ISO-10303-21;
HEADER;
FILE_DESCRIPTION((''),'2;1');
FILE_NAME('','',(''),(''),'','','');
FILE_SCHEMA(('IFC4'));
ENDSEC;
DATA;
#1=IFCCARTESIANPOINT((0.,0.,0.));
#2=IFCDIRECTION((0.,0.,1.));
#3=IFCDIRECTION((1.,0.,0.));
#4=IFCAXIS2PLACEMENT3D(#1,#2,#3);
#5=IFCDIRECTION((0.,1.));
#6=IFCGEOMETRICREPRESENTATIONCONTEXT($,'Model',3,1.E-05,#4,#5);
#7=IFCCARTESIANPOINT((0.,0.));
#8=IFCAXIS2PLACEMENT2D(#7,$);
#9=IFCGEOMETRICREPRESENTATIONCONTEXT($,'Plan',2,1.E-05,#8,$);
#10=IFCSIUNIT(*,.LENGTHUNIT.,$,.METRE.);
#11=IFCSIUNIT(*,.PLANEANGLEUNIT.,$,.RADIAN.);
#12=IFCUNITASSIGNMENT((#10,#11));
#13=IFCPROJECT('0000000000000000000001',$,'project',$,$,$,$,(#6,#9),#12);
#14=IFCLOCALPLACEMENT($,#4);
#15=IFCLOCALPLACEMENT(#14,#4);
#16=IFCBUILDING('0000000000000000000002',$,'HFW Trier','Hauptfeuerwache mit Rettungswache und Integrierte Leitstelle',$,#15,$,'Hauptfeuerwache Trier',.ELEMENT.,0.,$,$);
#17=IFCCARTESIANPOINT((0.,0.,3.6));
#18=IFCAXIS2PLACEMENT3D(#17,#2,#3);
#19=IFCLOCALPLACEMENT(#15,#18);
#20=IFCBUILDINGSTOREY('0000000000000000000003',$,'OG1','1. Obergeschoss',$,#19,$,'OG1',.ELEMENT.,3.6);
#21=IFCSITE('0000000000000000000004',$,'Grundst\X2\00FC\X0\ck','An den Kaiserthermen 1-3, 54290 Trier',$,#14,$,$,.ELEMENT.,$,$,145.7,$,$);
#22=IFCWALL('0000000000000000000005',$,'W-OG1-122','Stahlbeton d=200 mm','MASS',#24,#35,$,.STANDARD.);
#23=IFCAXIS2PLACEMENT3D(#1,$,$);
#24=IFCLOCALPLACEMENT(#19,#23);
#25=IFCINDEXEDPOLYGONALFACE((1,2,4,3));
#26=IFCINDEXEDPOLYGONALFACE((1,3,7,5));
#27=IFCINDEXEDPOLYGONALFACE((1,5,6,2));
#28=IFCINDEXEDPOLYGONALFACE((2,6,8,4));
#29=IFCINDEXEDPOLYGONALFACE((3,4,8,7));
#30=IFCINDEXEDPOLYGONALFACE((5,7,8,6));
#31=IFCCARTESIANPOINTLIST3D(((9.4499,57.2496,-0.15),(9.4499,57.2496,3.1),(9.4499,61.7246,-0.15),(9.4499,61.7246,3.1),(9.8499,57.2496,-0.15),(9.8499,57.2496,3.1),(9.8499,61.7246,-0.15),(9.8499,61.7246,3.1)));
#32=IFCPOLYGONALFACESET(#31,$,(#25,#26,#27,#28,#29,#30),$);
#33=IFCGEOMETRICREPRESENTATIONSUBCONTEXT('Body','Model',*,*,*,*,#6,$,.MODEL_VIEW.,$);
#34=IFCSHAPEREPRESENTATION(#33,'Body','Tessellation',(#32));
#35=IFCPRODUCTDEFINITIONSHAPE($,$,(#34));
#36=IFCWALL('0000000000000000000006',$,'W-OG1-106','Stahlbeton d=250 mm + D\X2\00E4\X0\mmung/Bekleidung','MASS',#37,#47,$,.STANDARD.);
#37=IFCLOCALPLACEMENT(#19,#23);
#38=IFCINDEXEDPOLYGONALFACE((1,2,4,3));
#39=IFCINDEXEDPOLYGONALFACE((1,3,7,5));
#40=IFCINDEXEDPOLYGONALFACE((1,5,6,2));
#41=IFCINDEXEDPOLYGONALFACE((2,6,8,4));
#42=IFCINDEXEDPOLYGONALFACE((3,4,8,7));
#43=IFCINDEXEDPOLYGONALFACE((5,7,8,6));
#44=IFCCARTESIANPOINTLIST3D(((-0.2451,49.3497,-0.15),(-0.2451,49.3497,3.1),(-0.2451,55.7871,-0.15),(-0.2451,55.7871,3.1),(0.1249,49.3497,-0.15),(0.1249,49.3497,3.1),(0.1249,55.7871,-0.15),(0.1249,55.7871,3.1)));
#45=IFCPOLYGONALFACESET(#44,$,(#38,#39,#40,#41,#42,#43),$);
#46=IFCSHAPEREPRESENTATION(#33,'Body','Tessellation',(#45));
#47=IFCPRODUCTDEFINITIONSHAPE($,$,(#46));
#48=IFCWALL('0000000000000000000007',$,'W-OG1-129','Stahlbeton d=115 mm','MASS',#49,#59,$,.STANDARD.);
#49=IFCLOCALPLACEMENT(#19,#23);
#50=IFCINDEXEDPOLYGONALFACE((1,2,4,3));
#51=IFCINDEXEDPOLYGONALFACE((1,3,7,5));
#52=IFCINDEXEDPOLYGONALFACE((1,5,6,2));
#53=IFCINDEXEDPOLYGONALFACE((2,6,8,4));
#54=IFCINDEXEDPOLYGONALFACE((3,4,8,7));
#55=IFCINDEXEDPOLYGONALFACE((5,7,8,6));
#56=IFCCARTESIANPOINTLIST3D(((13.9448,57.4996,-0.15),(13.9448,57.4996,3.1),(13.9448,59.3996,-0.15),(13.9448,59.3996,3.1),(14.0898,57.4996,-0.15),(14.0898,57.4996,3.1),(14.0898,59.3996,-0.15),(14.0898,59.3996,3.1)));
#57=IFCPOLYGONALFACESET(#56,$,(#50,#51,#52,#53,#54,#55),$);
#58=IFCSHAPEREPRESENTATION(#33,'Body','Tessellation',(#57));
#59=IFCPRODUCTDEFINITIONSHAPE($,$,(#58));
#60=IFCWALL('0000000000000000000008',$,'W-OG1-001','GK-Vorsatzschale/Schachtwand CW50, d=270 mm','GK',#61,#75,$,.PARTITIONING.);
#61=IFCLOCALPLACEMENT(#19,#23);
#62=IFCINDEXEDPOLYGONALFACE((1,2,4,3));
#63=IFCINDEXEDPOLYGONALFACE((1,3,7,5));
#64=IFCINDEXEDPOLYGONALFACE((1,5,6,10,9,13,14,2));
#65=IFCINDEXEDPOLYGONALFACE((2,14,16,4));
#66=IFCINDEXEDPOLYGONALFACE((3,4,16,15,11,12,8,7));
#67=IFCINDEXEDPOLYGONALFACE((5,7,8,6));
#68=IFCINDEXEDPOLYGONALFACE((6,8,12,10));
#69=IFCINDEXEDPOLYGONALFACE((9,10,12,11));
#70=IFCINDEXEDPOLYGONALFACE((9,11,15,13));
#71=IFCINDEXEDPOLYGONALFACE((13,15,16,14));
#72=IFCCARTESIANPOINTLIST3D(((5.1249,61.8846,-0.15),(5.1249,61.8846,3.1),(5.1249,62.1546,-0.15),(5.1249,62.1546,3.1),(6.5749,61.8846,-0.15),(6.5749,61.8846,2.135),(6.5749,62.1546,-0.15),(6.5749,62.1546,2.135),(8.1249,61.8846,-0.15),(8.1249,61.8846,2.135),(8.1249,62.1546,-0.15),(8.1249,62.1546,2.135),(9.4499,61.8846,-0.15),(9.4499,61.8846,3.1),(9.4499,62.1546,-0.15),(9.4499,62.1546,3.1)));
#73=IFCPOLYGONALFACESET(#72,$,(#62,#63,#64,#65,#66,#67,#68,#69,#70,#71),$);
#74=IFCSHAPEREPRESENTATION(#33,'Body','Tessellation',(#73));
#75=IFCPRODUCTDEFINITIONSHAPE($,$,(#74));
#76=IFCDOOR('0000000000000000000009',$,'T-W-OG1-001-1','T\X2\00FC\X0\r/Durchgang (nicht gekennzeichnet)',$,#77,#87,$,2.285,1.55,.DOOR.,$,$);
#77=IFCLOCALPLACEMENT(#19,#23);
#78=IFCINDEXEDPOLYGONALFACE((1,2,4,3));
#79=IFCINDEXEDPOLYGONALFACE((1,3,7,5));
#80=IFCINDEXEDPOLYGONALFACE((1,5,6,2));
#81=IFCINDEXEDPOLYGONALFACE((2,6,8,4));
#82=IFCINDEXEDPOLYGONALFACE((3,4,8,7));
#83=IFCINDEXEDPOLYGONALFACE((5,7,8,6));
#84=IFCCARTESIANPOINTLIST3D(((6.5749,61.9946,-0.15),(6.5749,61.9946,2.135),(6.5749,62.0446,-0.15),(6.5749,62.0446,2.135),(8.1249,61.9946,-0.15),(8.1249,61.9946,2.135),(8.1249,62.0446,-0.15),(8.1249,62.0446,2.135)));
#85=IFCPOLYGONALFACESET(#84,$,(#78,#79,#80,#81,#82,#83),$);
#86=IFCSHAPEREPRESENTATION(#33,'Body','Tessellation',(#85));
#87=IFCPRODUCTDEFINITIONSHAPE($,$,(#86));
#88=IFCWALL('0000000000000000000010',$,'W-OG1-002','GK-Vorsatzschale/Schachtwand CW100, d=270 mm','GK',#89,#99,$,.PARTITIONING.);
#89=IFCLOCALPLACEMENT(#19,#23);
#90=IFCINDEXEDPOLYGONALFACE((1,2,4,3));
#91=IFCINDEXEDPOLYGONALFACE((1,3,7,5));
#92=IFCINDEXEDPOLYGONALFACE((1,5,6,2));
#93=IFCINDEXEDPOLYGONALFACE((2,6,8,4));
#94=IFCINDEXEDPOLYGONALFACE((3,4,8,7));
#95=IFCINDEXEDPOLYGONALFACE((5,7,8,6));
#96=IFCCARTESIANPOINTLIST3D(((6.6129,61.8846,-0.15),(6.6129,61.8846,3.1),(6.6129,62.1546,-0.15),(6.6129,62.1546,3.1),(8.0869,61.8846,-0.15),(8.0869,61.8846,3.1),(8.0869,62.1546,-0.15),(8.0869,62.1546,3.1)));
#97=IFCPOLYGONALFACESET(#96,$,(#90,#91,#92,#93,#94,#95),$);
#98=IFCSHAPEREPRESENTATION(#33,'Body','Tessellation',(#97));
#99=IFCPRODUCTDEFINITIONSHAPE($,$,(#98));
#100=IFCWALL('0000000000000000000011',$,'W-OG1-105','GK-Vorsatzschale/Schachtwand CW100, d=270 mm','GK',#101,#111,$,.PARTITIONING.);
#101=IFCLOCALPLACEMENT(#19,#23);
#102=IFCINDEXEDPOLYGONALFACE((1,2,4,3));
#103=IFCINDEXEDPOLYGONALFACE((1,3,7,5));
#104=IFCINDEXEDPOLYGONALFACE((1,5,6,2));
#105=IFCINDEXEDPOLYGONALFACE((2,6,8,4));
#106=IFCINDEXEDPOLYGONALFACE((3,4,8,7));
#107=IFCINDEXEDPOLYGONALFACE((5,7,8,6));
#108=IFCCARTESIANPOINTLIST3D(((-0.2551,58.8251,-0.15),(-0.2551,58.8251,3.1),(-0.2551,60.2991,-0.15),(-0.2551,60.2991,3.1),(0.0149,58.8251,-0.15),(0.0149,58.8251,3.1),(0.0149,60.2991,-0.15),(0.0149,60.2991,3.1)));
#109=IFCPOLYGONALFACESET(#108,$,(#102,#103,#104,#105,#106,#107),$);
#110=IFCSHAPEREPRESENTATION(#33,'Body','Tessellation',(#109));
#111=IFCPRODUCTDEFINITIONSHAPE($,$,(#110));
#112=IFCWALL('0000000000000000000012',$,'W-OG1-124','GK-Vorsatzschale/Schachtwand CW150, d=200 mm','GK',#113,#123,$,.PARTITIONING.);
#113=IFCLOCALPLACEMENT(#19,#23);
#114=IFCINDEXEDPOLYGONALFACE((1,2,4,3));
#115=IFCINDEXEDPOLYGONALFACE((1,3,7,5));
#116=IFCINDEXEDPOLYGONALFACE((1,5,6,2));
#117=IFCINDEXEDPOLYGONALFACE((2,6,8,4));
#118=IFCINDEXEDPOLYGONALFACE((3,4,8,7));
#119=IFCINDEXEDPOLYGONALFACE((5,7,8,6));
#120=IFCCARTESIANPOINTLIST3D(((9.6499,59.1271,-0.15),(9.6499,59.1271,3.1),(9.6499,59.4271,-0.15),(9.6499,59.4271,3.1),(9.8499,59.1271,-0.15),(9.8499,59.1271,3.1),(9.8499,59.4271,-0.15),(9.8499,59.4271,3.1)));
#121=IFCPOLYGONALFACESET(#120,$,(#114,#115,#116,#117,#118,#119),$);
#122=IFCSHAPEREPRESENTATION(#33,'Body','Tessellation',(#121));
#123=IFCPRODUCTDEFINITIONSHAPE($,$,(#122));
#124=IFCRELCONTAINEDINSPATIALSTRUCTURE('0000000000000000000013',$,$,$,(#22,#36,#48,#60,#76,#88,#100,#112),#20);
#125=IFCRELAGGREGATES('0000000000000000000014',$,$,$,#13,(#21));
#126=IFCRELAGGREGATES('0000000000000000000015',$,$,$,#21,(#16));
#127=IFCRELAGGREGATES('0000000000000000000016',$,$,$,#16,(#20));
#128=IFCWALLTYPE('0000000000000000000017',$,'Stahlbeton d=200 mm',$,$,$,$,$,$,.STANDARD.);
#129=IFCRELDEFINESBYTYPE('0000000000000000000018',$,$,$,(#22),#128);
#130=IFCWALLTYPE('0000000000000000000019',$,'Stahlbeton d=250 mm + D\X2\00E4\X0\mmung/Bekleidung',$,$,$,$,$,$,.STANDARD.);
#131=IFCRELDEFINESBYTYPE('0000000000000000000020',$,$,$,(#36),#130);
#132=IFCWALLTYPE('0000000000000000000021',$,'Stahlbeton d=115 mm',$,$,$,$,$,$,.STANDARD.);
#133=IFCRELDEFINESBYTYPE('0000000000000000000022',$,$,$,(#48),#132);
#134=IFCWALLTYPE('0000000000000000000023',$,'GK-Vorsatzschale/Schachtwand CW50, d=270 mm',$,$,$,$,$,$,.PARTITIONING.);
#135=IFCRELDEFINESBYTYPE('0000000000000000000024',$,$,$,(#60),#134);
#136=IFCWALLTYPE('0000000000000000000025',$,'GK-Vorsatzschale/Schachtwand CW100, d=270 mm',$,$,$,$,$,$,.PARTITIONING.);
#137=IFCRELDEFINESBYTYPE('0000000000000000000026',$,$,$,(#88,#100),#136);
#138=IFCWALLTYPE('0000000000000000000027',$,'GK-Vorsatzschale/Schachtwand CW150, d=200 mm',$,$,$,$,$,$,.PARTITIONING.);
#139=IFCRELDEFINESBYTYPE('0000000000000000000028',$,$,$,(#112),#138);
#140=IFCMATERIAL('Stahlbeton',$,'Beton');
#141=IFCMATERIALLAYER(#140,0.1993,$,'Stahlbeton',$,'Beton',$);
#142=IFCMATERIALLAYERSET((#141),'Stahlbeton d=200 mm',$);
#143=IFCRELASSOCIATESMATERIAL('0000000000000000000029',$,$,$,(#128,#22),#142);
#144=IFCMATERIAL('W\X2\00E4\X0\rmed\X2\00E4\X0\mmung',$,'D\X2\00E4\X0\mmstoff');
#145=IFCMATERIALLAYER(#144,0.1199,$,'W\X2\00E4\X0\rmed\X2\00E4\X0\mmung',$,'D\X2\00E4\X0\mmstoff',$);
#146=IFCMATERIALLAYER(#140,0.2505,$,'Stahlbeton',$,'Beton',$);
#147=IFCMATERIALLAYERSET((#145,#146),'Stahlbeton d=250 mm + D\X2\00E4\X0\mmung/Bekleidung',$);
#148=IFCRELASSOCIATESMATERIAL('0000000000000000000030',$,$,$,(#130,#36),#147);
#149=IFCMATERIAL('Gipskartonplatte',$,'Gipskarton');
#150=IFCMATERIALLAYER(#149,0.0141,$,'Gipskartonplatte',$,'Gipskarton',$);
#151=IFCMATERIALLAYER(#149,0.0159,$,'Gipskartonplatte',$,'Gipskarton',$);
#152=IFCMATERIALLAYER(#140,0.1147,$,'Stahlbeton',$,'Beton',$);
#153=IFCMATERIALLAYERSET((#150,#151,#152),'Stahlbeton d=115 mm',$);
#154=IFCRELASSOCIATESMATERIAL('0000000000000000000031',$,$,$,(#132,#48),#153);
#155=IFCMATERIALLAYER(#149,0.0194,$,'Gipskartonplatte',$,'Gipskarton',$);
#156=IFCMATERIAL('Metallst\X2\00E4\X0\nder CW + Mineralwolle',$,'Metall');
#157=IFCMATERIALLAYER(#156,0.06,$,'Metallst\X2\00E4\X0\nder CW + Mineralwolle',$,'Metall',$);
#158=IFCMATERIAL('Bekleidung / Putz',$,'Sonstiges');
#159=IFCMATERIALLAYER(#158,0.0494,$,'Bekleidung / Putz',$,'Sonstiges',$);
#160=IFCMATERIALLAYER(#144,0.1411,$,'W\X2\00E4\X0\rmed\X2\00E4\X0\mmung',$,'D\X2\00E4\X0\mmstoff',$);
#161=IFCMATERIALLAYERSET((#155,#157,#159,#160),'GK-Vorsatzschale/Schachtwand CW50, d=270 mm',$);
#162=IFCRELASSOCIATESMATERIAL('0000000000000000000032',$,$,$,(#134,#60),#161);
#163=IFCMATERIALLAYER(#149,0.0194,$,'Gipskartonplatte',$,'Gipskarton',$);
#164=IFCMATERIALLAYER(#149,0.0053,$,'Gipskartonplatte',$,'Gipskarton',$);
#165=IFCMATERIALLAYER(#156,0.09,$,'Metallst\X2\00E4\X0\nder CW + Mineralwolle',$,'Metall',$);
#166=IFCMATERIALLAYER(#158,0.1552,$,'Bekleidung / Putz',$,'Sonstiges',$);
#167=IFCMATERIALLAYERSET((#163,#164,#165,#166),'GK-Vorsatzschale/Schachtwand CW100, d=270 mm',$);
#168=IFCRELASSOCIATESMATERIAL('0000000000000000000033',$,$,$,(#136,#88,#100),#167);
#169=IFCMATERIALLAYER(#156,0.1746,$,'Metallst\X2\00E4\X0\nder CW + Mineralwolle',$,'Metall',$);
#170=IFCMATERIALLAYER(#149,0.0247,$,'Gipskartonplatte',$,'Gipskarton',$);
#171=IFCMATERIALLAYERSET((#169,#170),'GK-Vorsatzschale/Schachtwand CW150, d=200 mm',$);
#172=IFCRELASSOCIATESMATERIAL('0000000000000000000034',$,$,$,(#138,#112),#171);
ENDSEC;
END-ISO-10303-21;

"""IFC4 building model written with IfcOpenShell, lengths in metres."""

from ifc_helpers import new_model, si_unit, direction, frame, frame_2d, origin_with_axes, origin_2d, place, context, subcontext, project, spatial, rectangle, extrude, material, layer, layer_set, layer_usage, type_object, element, fill, save


model = new_model("IFC4")

# Units and contexts
model_context = context("Model", 3, precision=1e-05, world=origin_with_axes(), true_north=direction((0.0, 1.0)))
plan_context = context("Plan", 2, precision=1e-05, world=origin_2d())
body_context = subcontext(model_context, "Body", "Model", "MODEL_VIEW")
ifc_project = project(units=[si_unit("LENGTHUNIT", "METRE"), si_unit("PLANEANGLEUNIT", "RADIAN")], contexts=[model_context, plan_context])

# Site, building, storey
site_placement = place(None, origin_with_axes())
site = spatial("IfcSite", under=ifc_project, at=site_placement, Name="Grundstück", Description="An den Kaiserthermen 1-3, 54290 Trier", CompositionType="ELEMENT", RefElevation=145.7)
building_placement = place(site_placement, origin_with_axes())
building = spatial("IfcBuilding", under=site, at=building_placement, Name="HFW Trier", Description="Hauptfeuerwache mit Rettungswache und Integrierte Leitstelle", LongName="Hauptfeuerwache Trier", CompositionType="ELEMENT", ElevationOfRefHeight=0.0)
storey_placement = place(building_placement, frame((0.0, 0.0, 3.6), z_axis=(0.0, 0.0, 1.0), x_axis=(1.0, 0.0, 0.0)))
storey = spatial("IfcBuildingStorey", under=building, at=storey_placement, Name="OG1", Description="1. Obergeschoss", LongName="OG1", CompositionType="ELEMENT", Elevation=3.6)

# Shared definitions
ifc_material_1 = material(Name="Stahlbeton", Category="Beton")

# Shared definitions
ifc_material_2 = material(Name="Gipskartonplatte", Category="Gipskarton")
ifc_material_3 = material(Name="Metallständer CW + Mineralwolle", Category="Metall")

# Walls
ifc_layer_1 = layer(ifc_material_1, 0.1993, Name="Stahlbeton", Category="Beton")
ifc_layer_set_1 = layer_set([ifc_layer_1], Name="Stahlbeton d=200 mm")
wall_type_1 = type_object("IfcWallType", Name="Stahlbeton d=200 mm", PredefinedType="STANDARD", material=ifc_layer_set_1)
ifc_layer_usage_1 = layer_usage(ifc_layer_set_1, "AXIS2", "POSITIVE", -0.2)
wall_1_placement = place(storey_placement, frame((9.6499, 61.7246, -0.15), z_axis=(0.0, 0.0, 1.0), x_axis=(0.0, -1.0, 0.0)))
element("IfcWall", 1, at=wall_1_placement, inside=storey, type_object=wall_type_1, material=ifc_layer_usage_1, Name="W-OG1-122", Description="Stahlbeton d=200 mm", ObjectType="MASS", PredefinedType="STANDARD", context=body_context, shape_type="SweptSolid", body=[
    extrude(rectangle(XDim=4.475, YDim=0.4, at=frame_2d((2.2375, 0.0))), origin_with_axes(), (0.0, 0.0, 1.0), 3.25),
])
ifc_material_4 = material(Name="Wärmedämmung", Category="Dämmstoff")
ifc_layer_2 = layer(ifc_material_4, 0.1199, Name="Wärmedämmung", Category="Dämmstoff")
ifc_layer_3 = layer(ifc_material_1, 0.2505, Name="Stahlbeton", Category="Beton")
ifc_layer_set_2 = layer_set([ifc_layer_2, ifc_layer_3], Name="Stahlbeton d=250 mm + Dämmung/Bekleidung")
ifc_layer_usage_2 = layer_usage(ifc_layer_set_2, "AXIS2", "POSITIVE", -0.185)
wall_type_2 = type_object("IfcWallType", Name="Stahlbeton d=250 mm + Dämmung/Bekleidung", PredefinedType="STANDARD", material=ifc_layer_set_2)
wall_2_placement = place(storey_placement, frame((-0.0601, 55.7871, -0.15), z_axis=(0.0, 0.0, 1.0), x_axis=(0.0, -1.0, 0.0)))
element("IfcWall", 2, at=wall_2_placement, inside=storey, type_object=wall_type_2, material=ifc_layer_usage_2, Name="W-OG1-106", Description="Stahlbeton d=250 mm + Dämmung/Bekleidung", ObjectType="MASS", PredefinedType="STANDARD", context=body_context, shape_type="SweptSolid", body=[
    extrude(rectangle(XDim=6.4374, YDim=0.37, at=frame_2d((3.2187, 0.0))), origin_with_axes(), (0.0, 0.0, 1.0), 3.25),
])
ifc_layer_4 = layer(ifc_material_2, 0.0141, Name="Gipskartonplatte", Category="Gipskarton")
ifc_layer_5 = layer(ifc_material_2, 0.0159, Name="Gipskartonplatte", Category="Gipskarton")
ifc_layer_6 = layer(ifc_material_1, 0.1147, Name="Stahlbeton", Category="Beton")
ifc_layer_set_3 = layer_set([ifc_layer_4, ifc_layer_5, ifc_layer_6], Name="Stahlbeton d=115 mm")
ifc_layer_usage_3 = layer_usage(ifc_layer_set_3, "AXIS2", "POSITIVE", -0.0725)
wall_type_3 = type_object("IfcWallType", Name="Stahlbeton d=115 mm", PredefinedType="STANDARD", material=ifc_layer_set_3)
wall_3_placement = place(storey_placement, frame((14.0173, 59.3996, -0.15), z_axis=(0.0, 0.0, 1.0), x_axis=(0.0, -1.0, 0.0)))
element("IfcWall", 3, at=wall_3_placement, inside=storey, type_object=wall_type_3, material=ifc_layer_usage_3, Name="W-OG1-129", Description="Stahlbeton d=115 mm", ObjectType="MASS", PredefinedType="STANDARD", context=body_context, shape_type="SweptSolid", body=[
    extrude(rectangle(XDim=1.9, YDim=0.145, at=frame_2d((0.95, 0.0))), origin_with_axes(), (0.0, 0.0, 1.0), 3.25),
])

# Wall, opening, door
ifc_layer_7 = layer(ifc_material_2, 0.0194, Name="Gipskartonplatte", Category="Gipskarton")
ifc_layer_8 = layer(ifc_material_3, 0.06, Name="Metallständer CW + Mineralwolle", Category="Metall")
ifc_material_5 = material(Name="Bekleidung / Putz", Category="Sonstiges")
ifc_layer_9 = layer(ifc_material_5, 0.0494, Name="Bekleidung / Putz", Category="Sonstiges")
ifc_layer_10 = layer(ifc_material_4, 0.1411, Name="Wärmedämmung", Category="Dämmstoff")
ifc_layer_set_4 = layer_set([ifc_layer_7, ifc_layer_8, ifc_layer_9, ifc_layer_10], Name="GK-Vorsatzschale/Schachtwand CW50, d=270 mm")
ifc_layer_usage_4 = layer_usage(ifc_layer_set_4, "AXIS2", "POSITIVE", -0.135)
wall_type_4 = type_object("IfcWallType", Name="GK-Vorsatzschale/Schachtwand CW50, d=270 mm", PredefinedType="PARTITIONING", material=ifc_layer_set_4)
wall_4_placement = place(storey_placement, frame((5.1249, 62.0196, -0.15), z_axis=(0.0, 0.0, 1.0), x_axis=(1.0, 0.0, 0.0)))
wall_4 = element("IfcWall", 4, at=wall_4_placement, inside=storey, type_object=wall_type_4, material=ifc_layer_usage_4, Name="W-OG1-001", Description="GK-Vorsatzschale/Schachtwand CW50, d=270 mm", ObjectType="GK", PredefinedType="PARTITIONING", context=body_context, shape_type="SweptSolid", body=[
    extrude(rectangle(XDim=4.325, YDim=0.27, at=frame_2d((2.1625, 0.0))), origin_with_axes(), (0.0, 0.0, 1.0), 3.25),
])
opening_1_placement = place(wall_4_placement, frame((1.45, 0.0, 0.0), z_axis=(0.0, 0.0, 1.0), x_axis=(1.0, 0.0, 0.0)))
opening_1 = element("IfcOpeningElement", 5, at=opening_1_placement, cuts=wall_4, PredefinedType="OPENING", context=body_context, shape_type="SweptSolid", body=[
    extrude(rectangle(XDim=1.55, YDim=0.37, at=frame_2d((0.775, 0.0))), origin_with_axes(), (0.0, 0.0, 1.0), 2.285),
])
door_1_placement = place(wall_4_placement, frame((1.45, 0.0, 0.0), z_axis=(0.0, 0.0, 1.0), x_axis=(1.0, 0.0, 0.0)))
door_1 = element("IfcDoor", 6, at=door_1_placement, inside=storey, Name="T-W-OG1-001-1", Description="Tür/Durchgang (nicht gekennzeichnet)", OverallHeight=2.285, OverallWidth=1.55, PredefinedType="DOOR", context=body_context, shape_type="SweptSolid", body=[
    extrude(rectangle(XDim=1.55, YDim=0.05, at=frame_2d((0.775, 0.0))), origin_with_axes(), (0.0, 0.0, 1.0), 2.285),
])
fill(opening_1, door_1)

# Walls
ifc_layer_11 = layer(ifc_material_2, 0.0194, Name="Gipskartonplatte", Category="Gipskarton")
ifc_layer_12 = layer(ifc_material_2, 0.0053, Name="Gipskartonplatte", Category="Gipskarton")
ifc_layer_13 = layer(ifc_material_3, 0.09, Name="Metallständer CW + Mineralwolle", Category="Metall")
ifc_layer_14 = layer(ifc_material_5, 0.1552, Name="Bekleidung / Putz", Category="Sonstiges")
ifc_layer_set_5 = layer_set([ifc_layer_11, ifc_layer_12, ifc_layer_13, ifc_layer_14], Name="GK-Vorsatzschale/Schachtwand CW100, d=270 mm")
ifc_layer_usage_5 = layer_usage(ifc_layer_set_5, "AXIS2", "POSITIVE", -0.135)
wall_type_5 = type_object("IfcWallType", Name="GK-Vorsatzschale/Schachtwand CW100, d=270 mm", PredefinedType="PARTITIONING", material=ifc_layer_set_5)
wall_5_placement = place(storey_placement, frame((6.6129, 62.0196, -0.15), z_axis=(0.0, 0.0, 1.0), x_axis=(1.0, 0.0, 0.0)))
element("IfcWall", 7, at=wall_5_placement, inside=storey, type_object=wall_type_5, material=ifc_layer_usage_5, Name="W-OG1-002", Description="GK-Vorsatzschale/Schachtwand CW100, d=270 mm", ObjectType="GK", PredefinedType="PARTITIONING", context=body_context, shape_type="SweptSolid", body=[
    extrude(rectangle(XDim=1.474, YDim=0.27, at=frame_2d((0.737, 0.0))), origin_with_axes(), (0.0, 0.0, 1.0), 3.25),
])
ifc_layer_usage_6 = layer_usage(ifc_layer_set_5, "AXIS2", "POSITIVE", -0.135)
wall_6_placement = place(storey_placement, frame((-0.1201, 60.2991, -0.15), z_axis=(0.0, 0.0, 1.0), x_axis=(0.0, -1.0, 0.0)))
element("IfcWall", 8, at=wall_6_placement, inside=storey, type_object=wall_type_5, material=ifc_layer_usage_6, Name="W-OG1-105", Description="GK-Vorsatzschale/Schachtwand CW100, d=270 mm", ObjectType="GK", PredefinedType="PARTITIONING", context=body_context, shape_type="SweptSolid", body=[
    extrude(rectangle(XDim=1.474, YDim=0.27, at=frame_2d((0.737, 0.0))), origin_with_axes(), (0.0, 0.0, 1.0), 3.25),
])
ifc_layer_15 = layer(ifc_material_3, 0.1746, Name="Metallständer CW + Mineralwolle", Category="Metall")
ifc_layer_16 = layer(ifc_material_2, 0.0247, Name="Gipskartonplatte", Category="Gipskarton")
ifc_layer_set_6 = layer_set([ifc_layer_15, ifc_layer_16], Name="GK-Vorsatzschale/Schachtwand CW150, d=200 mm")
ifc_layer_usage_7 = layer_usage(ifc_layer_set_6, "AXIS2", "POSITIVE", -0.1)
wall_type_6 = type_object("IfcWallType", Name="GK-Vorsatzschale/Schachtwand CW150, d=200 mm", PredefinedType="PARTITIONING", material=ifc_layer_set_6)
wall_7_placement = place(storey_placement, frame((9.7499, 59.4271, -0.15), z_axis=(0.0, 0.0, 1.0), x_axis=(0.0, -1.0, 0.0)))
element("IfcWall", 9, at=wall_7_placement, inside=storey, type_object=wall_type_6, material=ifc_layer_usage_7, Name="W-OG1-124", Description="GK-Vorsatzschale/Schachtwand CW150, d=200 mm", ObjectType="GK", PredefinedType="PARTITIONING", context=body_context, shape_type="SweptSolid", body=[
    extrude(rectangle(XDim=0.3, YDim=0.2, at=frame_2d((0.15, 0.0))), origin_with_axes(), (0.0, 0.0, 1.0), 3.25),
])

save(model, "model.ifc")
